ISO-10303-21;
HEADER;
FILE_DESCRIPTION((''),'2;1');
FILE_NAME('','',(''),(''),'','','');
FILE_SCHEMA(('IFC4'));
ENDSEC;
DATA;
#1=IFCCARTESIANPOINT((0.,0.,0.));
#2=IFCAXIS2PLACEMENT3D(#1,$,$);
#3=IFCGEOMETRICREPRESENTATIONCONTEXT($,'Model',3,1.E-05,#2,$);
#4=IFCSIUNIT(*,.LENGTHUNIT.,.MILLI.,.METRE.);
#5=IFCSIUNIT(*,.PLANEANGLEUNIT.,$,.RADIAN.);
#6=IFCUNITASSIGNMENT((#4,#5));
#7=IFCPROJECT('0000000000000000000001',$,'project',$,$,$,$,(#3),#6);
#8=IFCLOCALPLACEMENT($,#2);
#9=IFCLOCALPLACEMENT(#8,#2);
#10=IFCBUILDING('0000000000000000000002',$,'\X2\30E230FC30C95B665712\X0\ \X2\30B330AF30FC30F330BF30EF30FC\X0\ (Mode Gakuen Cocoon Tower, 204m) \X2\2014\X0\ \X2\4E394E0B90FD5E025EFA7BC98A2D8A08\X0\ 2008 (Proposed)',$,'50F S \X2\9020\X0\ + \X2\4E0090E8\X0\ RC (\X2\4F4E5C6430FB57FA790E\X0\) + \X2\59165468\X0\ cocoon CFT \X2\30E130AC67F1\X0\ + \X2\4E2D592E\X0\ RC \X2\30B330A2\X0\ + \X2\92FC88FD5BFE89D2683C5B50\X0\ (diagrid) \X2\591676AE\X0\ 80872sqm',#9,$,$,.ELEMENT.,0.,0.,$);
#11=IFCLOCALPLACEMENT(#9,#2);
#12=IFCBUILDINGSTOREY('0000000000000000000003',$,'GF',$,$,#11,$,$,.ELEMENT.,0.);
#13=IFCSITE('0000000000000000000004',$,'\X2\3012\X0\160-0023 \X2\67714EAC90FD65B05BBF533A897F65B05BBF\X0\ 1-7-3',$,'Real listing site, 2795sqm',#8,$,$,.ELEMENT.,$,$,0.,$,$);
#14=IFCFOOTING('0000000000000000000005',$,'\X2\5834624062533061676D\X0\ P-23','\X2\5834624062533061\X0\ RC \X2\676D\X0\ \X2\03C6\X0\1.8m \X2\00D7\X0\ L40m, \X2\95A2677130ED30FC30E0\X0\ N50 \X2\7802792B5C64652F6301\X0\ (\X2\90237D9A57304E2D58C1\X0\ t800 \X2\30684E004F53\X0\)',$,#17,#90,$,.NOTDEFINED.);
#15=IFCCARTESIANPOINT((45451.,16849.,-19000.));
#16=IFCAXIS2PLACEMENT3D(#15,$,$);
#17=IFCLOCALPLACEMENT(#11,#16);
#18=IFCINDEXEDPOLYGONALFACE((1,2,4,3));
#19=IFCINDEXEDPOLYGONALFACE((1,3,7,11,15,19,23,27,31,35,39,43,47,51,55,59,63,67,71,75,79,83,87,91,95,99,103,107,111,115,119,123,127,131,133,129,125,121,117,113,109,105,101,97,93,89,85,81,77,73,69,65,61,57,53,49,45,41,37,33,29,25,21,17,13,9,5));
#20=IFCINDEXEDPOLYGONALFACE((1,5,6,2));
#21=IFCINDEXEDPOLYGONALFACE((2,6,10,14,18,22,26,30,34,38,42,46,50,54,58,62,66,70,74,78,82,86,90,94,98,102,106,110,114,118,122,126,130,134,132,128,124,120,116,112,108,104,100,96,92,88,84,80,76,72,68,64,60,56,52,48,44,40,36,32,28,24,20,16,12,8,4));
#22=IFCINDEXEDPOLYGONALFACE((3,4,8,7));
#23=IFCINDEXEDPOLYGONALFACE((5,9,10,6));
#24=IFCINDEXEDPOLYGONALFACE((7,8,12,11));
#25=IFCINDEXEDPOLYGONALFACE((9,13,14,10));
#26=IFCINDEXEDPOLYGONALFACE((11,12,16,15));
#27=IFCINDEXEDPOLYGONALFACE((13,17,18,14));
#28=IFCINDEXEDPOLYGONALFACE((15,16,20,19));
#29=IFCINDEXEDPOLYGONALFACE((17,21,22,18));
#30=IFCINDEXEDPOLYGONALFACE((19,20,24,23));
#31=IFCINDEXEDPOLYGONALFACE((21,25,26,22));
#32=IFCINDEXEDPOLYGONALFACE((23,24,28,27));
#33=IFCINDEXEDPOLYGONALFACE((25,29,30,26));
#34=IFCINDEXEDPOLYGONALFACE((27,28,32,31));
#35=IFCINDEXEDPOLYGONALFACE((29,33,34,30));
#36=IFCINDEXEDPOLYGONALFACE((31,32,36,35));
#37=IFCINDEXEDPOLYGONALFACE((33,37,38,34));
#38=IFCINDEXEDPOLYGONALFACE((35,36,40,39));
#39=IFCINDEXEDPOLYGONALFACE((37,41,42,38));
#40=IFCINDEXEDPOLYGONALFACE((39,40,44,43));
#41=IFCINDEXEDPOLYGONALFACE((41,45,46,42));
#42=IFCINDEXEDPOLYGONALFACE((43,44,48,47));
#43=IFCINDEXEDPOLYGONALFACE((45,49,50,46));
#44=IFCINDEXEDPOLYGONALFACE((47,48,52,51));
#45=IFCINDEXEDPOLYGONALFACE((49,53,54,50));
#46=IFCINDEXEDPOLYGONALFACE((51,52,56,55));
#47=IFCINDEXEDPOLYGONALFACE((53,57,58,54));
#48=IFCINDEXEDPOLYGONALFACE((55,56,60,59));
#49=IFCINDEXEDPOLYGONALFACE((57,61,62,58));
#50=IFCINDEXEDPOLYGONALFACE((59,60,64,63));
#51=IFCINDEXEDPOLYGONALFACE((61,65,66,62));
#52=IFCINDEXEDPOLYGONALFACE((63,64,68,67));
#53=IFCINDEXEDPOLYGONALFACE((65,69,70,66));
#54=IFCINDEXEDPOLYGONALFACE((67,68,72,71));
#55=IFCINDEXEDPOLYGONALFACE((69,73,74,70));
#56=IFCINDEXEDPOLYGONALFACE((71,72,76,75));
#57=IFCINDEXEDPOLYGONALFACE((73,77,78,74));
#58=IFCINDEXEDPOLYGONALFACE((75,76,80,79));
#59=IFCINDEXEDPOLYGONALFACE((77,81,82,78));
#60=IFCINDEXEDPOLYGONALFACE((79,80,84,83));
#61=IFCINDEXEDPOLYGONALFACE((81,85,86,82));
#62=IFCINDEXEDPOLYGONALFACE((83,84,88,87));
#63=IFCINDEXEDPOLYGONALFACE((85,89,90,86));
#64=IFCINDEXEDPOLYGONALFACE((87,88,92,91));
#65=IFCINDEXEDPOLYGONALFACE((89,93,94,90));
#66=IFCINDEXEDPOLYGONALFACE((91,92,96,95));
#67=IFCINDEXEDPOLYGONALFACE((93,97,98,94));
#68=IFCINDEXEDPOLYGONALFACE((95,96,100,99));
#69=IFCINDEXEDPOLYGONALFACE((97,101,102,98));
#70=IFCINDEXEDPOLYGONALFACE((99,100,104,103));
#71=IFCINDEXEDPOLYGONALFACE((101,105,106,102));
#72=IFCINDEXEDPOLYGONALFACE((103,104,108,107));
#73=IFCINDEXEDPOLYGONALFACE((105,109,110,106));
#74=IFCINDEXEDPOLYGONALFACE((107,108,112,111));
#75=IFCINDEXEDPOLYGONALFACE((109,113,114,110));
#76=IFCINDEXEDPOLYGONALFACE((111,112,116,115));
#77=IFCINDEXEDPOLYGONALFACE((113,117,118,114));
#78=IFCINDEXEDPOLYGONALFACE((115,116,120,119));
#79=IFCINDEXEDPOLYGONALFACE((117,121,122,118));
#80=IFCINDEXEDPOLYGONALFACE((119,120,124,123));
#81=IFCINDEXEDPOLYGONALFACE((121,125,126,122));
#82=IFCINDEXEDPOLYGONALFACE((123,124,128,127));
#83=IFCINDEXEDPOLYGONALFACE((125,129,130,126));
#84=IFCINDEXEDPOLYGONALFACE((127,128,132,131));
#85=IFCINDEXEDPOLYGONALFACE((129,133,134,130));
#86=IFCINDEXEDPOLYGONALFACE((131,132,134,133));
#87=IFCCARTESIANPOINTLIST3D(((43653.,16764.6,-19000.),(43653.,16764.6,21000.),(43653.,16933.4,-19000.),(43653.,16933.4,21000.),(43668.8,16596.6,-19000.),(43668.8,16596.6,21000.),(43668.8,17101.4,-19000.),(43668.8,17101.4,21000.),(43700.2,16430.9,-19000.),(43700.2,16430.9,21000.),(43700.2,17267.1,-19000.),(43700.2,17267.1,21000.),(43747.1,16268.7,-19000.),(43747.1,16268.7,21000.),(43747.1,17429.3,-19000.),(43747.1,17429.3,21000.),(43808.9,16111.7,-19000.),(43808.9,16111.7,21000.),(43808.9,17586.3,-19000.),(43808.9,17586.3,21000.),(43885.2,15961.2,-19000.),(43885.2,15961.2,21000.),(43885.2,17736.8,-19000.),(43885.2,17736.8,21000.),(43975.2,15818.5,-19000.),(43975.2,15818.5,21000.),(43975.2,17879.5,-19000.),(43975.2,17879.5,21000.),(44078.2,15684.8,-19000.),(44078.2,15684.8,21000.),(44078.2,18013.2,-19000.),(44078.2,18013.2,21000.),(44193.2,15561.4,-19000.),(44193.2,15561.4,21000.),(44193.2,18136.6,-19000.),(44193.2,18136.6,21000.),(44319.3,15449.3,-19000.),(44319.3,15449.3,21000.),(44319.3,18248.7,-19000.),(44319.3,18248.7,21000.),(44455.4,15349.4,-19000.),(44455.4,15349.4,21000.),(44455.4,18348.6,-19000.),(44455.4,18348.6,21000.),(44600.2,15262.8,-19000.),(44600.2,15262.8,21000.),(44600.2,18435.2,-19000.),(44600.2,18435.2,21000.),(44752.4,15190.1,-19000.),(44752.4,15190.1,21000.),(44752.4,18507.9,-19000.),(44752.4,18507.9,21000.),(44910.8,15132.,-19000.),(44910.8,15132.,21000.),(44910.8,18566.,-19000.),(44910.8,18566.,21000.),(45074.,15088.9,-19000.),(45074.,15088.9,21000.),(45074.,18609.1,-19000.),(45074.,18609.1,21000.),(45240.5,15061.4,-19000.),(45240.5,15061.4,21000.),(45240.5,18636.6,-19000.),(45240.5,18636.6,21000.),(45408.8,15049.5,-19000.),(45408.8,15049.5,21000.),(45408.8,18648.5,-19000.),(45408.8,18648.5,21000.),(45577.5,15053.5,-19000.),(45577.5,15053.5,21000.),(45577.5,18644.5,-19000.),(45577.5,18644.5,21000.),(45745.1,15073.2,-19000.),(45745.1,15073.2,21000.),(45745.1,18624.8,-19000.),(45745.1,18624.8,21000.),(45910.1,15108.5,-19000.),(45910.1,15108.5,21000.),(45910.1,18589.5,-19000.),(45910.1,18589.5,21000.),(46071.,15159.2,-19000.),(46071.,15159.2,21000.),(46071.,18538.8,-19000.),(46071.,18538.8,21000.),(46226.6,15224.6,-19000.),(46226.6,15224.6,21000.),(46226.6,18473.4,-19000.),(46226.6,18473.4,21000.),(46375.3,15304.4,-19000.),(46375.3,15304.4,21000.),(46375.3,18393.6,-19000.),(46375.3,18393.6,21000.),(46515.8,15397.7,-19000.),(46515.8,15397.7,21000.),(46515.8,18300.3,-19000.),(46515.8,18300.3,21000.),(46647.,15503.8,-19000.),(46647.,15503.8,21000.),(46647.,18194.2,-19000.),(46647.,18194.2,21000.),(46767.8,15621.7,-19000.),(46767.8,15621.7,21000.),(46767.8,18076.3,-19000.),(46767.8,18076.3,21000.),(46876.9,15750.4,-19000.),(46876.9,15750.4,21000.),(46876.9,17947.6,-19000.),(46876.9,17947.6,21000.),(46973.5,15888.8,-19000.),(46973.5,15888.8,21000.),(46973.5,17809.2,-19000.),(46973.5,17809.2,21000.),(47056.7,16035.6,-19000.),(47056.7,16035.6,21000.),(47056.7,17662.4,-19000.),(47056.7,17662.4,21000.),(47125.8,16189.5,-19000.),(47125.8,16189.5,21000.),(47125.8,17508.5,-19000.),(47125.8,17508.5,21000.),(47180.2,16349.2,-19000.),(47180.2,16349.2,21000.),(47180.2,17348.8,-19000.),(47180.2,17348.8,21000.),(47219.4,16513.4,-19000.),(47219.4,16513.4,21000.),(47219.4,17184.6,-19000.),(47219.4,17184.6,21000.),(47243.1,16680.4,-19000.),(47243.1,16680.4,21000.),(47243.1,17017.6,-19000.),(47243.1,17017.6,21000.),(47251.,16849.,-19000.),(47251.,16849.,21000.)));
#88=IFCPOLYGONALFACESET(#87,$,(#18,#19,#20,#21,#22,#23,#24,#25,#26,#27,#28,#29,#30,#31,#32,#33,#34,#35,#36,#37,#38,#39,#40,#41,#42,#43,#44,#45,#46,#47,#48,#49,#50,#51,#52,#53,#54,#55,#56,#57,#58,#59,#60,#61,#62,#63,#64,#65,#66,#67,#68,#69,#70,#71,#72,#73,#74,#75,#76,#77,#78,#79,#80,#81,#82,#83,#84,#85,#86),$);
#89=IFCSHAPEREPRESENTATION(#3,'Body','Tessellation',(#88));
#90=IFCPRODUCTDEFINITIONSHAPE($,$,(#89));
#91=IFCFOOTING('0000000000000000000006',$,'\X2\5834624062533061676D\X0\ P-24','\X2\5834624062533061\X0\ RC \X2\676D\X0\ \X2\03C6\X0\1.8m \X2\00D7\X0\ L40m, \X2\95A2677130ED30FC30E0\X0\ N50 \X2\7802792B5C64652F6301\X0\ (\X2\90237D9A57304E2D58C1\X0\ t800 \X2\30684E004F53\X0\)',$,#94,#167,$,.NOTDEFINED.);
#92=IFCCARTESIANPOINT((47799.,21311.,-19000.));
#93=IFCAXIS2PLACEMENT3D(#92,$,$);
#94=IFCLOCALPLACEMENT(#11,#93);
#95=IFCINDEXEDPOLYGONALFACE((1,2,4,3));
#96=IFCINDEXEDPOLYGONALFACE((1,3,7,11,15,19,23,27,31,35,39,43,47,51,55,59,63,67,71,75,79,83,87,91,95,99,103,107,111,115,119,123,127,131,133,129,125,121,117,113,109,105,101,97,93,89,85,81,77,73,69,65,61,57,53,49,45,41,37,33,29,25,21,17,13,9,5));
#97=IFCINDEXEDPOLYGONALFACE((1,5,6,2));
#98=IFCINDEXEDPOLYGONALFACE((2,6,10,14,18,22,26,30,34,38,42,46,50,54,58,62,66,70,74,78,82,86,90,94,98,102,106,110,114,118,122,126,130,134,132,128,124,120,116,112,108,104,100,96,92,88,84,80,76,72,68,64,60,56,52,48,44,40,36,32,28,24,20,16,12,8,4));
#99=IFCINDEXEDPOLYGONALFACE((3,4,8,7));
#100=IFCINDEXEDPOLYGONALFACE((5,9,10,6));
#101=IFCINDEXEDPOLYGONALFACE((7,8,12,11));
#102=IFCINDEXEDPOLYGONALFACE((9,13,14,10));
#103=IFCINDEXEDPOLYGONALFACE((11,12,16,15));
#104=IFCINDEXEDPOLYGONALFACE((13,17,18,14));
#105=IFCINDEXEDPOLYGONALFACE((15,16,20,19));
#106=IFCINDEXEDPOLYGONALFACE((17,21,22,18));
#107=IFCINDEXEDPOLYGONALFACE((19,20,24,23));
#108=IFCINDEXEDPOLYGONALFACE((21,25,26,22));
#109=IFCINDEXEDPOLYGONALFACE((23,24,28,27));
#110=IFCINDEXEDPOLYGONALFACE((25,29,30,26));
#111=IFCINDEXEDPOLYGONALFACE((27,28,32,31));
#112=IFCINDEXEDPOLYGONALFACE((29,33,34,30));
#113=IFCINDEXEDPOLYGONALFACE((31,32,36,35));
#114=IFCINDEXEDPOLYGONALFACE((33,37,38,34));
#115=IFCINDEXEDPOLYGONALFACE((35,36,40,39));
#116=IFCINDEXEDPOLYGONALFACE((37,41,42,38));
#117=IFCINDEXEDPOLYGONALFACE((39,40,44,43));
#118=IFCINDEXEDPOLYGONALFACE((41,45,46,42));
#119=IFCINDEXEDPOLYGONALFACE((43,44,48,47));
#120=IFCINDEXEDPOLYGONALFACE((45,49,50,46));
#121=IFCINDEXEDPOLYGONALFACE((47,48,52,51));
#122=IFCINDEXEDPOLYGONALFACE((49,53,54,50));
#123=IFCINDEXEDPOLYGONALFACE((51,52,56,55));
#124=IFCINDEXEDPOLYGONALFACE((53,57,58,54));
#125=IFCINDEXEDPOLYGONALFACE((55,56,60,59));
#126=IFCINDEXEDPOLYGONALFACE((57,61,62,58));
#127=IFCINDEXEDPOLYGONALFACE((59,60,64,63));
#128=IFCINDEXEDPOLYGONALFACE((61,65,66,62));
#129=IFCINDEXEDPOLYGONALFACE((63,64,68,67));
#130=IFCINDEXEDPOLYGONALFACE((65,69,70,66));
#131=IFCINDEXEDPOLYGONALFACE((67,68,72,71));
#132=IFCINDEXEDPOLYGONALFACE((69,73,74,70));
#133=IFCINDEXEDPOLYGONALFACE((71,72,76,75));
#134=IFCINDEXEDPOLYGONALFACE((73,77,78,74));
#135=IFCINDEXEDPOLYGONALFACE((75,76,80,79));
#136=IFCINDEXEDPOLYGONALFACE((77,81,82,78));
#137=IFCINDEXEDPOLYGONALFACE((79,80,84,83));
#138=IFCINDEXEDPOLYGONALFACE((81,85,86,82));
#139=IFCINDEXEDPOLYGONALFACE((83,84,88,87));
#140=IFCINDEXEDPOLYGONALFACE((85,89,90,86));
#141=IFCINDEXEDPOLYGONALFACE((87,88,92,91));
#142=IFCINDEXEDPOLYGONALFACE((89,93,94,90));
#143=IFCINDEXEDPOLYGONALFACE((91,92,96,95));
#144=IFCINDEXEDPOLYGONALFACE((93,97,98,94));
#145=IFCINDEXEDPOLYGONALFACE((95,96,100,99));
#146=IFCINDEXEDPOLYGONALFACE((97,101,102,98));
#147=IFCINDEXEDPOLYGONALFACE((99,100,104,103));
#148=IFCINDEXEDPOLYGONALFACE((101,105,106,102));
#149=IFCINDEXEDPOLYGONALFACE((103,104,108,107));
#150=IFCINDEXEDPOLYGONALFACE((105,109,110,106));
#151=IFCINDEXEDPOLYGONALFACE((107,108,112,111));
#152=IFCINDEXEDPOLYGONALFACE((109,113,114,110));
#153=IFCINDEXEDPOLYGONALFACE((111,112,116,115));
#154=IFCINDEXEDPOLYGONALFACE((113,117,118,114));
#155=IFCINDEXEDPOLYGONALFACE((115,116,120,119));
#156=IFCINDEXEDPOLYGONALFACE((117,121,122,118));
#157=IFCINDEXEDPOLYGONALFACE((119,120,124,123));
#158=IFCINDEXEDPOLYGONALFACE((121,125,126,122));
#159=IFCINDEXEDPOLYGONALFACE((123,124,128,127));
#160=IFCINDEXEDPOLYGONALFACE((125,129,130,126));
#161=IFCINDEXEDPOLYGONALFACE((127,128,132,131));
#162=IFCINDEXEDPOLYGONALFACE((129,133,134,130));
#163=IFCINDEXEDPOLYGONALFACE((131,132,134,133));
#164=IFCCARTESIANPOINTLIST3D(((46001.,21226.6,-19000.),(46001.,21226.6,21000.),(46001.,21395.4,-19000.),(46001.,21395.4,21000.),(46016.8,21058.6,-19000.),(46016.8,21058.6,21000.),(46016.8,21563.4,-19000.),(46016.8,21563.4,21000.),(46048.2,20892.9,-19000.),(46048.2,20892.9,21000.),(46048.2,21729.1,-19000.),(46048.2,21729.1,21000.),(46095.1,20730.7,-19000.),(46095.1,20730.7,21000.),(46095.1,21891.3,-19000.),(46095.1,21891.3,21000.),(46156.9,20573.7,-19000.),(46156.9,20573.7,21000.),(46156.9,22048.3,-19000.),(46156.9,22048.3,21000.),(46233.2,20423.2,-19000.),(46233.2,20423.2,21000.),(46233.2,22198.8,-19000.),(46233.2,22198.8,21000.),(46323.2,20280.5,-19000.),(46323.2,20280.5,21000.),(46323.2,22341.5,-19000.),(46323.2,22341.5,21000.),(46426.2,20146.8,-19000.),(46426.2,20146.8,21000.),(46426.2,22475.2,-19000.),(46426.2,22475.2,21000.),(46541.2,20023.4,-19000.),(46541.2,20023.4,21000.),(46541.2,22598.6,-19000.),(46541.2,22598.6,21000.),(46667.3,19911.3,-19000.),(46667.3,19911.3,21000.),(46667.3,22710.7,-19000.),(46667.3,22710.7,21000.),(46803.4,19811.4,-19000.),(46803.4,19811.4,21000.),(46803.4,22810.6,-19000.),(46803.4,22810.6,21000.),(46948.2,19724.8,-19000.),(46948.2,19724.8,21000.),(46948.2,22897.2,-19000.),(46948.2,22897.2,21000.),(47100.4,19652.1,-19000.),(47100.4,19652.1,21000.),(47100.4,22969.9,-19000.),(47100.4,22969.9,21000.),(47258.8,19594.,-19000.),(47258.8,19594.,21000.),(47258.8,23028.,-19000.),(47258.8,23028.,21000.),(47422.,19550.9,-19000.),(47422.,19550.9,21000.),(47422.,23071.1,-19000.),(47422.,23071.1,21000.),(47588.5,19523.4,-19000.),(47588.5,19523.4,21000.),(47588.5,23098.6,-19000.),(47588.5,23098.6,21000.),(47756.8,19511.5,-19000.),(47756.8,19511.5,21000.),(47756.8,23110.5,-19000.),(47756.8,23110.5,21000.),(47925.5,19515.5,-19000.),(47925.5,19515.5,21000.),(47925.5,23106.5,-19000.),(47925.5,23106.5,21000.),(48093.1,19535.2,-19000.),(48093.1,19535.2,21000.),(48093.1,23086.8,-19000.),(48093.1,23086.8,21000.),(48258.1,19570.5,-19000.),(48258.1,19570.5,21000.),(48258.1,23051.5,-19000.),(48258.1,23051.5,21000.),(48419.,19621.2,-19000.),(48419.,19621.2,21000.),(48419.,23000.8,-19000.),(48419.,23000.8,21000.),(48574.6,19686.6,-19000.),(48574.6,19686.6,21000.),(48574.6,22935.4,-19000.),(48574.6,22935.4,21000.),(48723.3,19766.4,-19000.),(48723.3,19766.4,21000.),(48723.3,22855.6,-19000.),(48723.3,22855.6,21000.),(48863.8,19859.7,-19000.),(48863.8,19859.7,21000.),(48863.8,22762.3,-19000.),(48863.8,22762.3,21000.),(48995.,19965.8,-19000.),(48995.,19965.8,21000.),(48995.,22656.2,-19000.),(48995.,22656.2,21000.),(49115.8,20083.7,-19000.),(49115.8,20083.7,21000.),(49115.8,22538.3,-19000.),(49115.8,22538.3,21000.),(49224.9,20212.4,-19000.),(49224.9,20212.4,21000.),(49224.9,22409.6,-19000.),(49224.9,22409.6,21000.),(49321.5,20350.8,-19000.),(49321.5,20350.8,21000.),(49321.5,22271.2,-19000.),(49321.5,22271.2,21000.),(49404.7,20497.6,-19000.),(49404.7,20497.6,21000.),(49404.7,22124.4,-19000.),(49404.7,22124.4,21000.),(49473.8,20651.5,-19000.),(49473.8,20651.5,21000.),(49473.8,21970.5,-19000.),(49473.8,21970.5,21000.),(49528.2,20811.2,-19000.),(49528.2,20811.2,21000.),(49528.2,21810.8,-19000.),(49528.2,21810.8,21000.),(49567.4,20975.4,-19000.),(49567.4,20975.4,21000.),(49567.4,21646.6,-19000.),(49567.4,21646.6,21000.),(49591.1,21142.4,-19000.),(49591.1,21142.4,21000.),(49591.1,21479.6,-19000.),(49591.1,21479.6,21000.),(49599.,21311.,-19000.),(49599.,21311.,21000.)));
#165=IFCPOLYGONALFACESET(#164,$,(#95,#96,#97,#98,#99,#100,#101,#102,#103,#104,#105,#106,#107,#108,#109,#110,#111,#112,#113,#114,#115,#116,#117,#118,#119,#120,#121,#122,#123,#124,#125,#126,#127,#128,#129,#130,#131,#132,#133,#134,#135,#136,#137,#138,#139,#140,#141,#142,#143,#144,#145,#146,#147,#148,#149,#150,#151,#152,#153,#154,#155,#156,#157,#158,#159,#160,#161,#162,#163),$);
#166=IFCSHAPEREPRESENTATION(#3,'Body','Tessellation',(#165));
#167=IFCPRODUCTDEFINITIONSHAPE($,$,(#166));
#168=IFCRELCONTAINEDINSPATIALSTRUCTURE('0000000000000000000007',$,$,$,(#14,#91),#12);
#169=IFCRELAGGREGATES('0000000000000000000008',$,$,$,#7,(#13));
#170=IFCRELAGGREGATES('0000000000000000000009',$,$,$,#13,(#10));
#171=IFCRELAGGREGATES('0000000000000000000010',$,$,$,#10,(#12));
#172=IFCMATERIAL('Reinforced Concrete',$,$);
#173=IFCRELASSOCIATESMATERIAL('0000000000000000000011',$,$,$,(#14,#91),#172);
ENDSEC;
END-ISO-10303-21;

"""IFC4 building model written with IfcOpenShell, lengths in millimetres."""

from ifc_helpers import new_model, si_unit, frame, origin, origin_2d, place, context, project, spatial, circle, extrude, material, element, save


model = new_model("IFC4")

# Units and contexts
model_context = context("Model", 3, precision=1e-05, world=origin())
ifc_project = project(units=[si_unit("LENGTHUNIT", "METRE", prefix="MILLI"), si_unit("PLANEANGLEUNIT", "RADIAN")], contexts=[model_context])

# Site, building, storey
site_placement = place(None, origin())
site = spatial("IfcSite", under=ifc_project, at=site_placement, Name="〒160-0023 東京都新宿区西新宿 1-7-3", ObjectType="Real listing site, 2795sqm", CompositionType="ELEMENT", RefElevation=0.0)
building_placement = place(site_placement, origin())
building = spatial("IfcBuilding", under=site, at=building_placement, Name="モード学園 コクーンタワー (Mode Gakuen Cocoon Tower, 204m) — 丹下都市建築設計 2008 (Proposed)", ObjectType="50F S 造 + 一部 RC (低層・基礎) + 外周 cocoon CFT メガ柱 + 中央 RC コア + 鋼製対角格子 (diagrid) 外皮 80872sqm", CompositionType="ELEMENT", ElevationOfRefHeight=0.0, ElevationOfTerrain=0.0)
storey_placement = place(building_placement, origin())
storey = spatial("IfcBuildingStorey", under=building, at=storey_placement, Name="GF", CompositionType="ELEMENT", Elevation=0.0)

# Footings
ifc_material_1 = material(Name="Reinforced Concrete")
footing_1_placement = place(storey_placement, frame((45451.0, 16849.0, -19000.0)))
element("IfcFooting", 1, at=footing_1_placement, inside=storey, material=ifc_material_1, Name="場所打ち杭 P-23", Description="場所打ち RC 杭 φ1.8m × L40m, 関東ローム N50 砂礫層支持 (連続地中壁 t800 と一体)", PredefinedType="NOTDEFINED", context=model_context, shape_type="SweptSolid", body=[
    extrude(circle(Radius=1800.0, at=origin_2d()), frame((45451.0, 16849.0, -19000.0)), (0.0, 0.0, 1.0), 40000.0),
])
footing_2_placement = place(storey_placement, frame((47799.0, 21311.0, -19000.0)))
element("IfcFooting", 2, at=footing_2_placement, inside=storey, material=ifc_material_1, Name="場所打ち杭 P-24", Description="場所打ち RC 杭 φ1.8m × L40m, 関東ローム N50 砂礫層支持 (連続地中壁 t800 と一体)", PredefinedType="NOTDEFINED", context=model_context, shape_type="SweptSolid", body=[
    extrude(circle(Radius=1800.0, at=origin_2d()), frame((47799.0, 21311.0, -19000.0)), (0.0, 0.0, 1.0), 40000.0),
])

save(model, "model.ifc")
